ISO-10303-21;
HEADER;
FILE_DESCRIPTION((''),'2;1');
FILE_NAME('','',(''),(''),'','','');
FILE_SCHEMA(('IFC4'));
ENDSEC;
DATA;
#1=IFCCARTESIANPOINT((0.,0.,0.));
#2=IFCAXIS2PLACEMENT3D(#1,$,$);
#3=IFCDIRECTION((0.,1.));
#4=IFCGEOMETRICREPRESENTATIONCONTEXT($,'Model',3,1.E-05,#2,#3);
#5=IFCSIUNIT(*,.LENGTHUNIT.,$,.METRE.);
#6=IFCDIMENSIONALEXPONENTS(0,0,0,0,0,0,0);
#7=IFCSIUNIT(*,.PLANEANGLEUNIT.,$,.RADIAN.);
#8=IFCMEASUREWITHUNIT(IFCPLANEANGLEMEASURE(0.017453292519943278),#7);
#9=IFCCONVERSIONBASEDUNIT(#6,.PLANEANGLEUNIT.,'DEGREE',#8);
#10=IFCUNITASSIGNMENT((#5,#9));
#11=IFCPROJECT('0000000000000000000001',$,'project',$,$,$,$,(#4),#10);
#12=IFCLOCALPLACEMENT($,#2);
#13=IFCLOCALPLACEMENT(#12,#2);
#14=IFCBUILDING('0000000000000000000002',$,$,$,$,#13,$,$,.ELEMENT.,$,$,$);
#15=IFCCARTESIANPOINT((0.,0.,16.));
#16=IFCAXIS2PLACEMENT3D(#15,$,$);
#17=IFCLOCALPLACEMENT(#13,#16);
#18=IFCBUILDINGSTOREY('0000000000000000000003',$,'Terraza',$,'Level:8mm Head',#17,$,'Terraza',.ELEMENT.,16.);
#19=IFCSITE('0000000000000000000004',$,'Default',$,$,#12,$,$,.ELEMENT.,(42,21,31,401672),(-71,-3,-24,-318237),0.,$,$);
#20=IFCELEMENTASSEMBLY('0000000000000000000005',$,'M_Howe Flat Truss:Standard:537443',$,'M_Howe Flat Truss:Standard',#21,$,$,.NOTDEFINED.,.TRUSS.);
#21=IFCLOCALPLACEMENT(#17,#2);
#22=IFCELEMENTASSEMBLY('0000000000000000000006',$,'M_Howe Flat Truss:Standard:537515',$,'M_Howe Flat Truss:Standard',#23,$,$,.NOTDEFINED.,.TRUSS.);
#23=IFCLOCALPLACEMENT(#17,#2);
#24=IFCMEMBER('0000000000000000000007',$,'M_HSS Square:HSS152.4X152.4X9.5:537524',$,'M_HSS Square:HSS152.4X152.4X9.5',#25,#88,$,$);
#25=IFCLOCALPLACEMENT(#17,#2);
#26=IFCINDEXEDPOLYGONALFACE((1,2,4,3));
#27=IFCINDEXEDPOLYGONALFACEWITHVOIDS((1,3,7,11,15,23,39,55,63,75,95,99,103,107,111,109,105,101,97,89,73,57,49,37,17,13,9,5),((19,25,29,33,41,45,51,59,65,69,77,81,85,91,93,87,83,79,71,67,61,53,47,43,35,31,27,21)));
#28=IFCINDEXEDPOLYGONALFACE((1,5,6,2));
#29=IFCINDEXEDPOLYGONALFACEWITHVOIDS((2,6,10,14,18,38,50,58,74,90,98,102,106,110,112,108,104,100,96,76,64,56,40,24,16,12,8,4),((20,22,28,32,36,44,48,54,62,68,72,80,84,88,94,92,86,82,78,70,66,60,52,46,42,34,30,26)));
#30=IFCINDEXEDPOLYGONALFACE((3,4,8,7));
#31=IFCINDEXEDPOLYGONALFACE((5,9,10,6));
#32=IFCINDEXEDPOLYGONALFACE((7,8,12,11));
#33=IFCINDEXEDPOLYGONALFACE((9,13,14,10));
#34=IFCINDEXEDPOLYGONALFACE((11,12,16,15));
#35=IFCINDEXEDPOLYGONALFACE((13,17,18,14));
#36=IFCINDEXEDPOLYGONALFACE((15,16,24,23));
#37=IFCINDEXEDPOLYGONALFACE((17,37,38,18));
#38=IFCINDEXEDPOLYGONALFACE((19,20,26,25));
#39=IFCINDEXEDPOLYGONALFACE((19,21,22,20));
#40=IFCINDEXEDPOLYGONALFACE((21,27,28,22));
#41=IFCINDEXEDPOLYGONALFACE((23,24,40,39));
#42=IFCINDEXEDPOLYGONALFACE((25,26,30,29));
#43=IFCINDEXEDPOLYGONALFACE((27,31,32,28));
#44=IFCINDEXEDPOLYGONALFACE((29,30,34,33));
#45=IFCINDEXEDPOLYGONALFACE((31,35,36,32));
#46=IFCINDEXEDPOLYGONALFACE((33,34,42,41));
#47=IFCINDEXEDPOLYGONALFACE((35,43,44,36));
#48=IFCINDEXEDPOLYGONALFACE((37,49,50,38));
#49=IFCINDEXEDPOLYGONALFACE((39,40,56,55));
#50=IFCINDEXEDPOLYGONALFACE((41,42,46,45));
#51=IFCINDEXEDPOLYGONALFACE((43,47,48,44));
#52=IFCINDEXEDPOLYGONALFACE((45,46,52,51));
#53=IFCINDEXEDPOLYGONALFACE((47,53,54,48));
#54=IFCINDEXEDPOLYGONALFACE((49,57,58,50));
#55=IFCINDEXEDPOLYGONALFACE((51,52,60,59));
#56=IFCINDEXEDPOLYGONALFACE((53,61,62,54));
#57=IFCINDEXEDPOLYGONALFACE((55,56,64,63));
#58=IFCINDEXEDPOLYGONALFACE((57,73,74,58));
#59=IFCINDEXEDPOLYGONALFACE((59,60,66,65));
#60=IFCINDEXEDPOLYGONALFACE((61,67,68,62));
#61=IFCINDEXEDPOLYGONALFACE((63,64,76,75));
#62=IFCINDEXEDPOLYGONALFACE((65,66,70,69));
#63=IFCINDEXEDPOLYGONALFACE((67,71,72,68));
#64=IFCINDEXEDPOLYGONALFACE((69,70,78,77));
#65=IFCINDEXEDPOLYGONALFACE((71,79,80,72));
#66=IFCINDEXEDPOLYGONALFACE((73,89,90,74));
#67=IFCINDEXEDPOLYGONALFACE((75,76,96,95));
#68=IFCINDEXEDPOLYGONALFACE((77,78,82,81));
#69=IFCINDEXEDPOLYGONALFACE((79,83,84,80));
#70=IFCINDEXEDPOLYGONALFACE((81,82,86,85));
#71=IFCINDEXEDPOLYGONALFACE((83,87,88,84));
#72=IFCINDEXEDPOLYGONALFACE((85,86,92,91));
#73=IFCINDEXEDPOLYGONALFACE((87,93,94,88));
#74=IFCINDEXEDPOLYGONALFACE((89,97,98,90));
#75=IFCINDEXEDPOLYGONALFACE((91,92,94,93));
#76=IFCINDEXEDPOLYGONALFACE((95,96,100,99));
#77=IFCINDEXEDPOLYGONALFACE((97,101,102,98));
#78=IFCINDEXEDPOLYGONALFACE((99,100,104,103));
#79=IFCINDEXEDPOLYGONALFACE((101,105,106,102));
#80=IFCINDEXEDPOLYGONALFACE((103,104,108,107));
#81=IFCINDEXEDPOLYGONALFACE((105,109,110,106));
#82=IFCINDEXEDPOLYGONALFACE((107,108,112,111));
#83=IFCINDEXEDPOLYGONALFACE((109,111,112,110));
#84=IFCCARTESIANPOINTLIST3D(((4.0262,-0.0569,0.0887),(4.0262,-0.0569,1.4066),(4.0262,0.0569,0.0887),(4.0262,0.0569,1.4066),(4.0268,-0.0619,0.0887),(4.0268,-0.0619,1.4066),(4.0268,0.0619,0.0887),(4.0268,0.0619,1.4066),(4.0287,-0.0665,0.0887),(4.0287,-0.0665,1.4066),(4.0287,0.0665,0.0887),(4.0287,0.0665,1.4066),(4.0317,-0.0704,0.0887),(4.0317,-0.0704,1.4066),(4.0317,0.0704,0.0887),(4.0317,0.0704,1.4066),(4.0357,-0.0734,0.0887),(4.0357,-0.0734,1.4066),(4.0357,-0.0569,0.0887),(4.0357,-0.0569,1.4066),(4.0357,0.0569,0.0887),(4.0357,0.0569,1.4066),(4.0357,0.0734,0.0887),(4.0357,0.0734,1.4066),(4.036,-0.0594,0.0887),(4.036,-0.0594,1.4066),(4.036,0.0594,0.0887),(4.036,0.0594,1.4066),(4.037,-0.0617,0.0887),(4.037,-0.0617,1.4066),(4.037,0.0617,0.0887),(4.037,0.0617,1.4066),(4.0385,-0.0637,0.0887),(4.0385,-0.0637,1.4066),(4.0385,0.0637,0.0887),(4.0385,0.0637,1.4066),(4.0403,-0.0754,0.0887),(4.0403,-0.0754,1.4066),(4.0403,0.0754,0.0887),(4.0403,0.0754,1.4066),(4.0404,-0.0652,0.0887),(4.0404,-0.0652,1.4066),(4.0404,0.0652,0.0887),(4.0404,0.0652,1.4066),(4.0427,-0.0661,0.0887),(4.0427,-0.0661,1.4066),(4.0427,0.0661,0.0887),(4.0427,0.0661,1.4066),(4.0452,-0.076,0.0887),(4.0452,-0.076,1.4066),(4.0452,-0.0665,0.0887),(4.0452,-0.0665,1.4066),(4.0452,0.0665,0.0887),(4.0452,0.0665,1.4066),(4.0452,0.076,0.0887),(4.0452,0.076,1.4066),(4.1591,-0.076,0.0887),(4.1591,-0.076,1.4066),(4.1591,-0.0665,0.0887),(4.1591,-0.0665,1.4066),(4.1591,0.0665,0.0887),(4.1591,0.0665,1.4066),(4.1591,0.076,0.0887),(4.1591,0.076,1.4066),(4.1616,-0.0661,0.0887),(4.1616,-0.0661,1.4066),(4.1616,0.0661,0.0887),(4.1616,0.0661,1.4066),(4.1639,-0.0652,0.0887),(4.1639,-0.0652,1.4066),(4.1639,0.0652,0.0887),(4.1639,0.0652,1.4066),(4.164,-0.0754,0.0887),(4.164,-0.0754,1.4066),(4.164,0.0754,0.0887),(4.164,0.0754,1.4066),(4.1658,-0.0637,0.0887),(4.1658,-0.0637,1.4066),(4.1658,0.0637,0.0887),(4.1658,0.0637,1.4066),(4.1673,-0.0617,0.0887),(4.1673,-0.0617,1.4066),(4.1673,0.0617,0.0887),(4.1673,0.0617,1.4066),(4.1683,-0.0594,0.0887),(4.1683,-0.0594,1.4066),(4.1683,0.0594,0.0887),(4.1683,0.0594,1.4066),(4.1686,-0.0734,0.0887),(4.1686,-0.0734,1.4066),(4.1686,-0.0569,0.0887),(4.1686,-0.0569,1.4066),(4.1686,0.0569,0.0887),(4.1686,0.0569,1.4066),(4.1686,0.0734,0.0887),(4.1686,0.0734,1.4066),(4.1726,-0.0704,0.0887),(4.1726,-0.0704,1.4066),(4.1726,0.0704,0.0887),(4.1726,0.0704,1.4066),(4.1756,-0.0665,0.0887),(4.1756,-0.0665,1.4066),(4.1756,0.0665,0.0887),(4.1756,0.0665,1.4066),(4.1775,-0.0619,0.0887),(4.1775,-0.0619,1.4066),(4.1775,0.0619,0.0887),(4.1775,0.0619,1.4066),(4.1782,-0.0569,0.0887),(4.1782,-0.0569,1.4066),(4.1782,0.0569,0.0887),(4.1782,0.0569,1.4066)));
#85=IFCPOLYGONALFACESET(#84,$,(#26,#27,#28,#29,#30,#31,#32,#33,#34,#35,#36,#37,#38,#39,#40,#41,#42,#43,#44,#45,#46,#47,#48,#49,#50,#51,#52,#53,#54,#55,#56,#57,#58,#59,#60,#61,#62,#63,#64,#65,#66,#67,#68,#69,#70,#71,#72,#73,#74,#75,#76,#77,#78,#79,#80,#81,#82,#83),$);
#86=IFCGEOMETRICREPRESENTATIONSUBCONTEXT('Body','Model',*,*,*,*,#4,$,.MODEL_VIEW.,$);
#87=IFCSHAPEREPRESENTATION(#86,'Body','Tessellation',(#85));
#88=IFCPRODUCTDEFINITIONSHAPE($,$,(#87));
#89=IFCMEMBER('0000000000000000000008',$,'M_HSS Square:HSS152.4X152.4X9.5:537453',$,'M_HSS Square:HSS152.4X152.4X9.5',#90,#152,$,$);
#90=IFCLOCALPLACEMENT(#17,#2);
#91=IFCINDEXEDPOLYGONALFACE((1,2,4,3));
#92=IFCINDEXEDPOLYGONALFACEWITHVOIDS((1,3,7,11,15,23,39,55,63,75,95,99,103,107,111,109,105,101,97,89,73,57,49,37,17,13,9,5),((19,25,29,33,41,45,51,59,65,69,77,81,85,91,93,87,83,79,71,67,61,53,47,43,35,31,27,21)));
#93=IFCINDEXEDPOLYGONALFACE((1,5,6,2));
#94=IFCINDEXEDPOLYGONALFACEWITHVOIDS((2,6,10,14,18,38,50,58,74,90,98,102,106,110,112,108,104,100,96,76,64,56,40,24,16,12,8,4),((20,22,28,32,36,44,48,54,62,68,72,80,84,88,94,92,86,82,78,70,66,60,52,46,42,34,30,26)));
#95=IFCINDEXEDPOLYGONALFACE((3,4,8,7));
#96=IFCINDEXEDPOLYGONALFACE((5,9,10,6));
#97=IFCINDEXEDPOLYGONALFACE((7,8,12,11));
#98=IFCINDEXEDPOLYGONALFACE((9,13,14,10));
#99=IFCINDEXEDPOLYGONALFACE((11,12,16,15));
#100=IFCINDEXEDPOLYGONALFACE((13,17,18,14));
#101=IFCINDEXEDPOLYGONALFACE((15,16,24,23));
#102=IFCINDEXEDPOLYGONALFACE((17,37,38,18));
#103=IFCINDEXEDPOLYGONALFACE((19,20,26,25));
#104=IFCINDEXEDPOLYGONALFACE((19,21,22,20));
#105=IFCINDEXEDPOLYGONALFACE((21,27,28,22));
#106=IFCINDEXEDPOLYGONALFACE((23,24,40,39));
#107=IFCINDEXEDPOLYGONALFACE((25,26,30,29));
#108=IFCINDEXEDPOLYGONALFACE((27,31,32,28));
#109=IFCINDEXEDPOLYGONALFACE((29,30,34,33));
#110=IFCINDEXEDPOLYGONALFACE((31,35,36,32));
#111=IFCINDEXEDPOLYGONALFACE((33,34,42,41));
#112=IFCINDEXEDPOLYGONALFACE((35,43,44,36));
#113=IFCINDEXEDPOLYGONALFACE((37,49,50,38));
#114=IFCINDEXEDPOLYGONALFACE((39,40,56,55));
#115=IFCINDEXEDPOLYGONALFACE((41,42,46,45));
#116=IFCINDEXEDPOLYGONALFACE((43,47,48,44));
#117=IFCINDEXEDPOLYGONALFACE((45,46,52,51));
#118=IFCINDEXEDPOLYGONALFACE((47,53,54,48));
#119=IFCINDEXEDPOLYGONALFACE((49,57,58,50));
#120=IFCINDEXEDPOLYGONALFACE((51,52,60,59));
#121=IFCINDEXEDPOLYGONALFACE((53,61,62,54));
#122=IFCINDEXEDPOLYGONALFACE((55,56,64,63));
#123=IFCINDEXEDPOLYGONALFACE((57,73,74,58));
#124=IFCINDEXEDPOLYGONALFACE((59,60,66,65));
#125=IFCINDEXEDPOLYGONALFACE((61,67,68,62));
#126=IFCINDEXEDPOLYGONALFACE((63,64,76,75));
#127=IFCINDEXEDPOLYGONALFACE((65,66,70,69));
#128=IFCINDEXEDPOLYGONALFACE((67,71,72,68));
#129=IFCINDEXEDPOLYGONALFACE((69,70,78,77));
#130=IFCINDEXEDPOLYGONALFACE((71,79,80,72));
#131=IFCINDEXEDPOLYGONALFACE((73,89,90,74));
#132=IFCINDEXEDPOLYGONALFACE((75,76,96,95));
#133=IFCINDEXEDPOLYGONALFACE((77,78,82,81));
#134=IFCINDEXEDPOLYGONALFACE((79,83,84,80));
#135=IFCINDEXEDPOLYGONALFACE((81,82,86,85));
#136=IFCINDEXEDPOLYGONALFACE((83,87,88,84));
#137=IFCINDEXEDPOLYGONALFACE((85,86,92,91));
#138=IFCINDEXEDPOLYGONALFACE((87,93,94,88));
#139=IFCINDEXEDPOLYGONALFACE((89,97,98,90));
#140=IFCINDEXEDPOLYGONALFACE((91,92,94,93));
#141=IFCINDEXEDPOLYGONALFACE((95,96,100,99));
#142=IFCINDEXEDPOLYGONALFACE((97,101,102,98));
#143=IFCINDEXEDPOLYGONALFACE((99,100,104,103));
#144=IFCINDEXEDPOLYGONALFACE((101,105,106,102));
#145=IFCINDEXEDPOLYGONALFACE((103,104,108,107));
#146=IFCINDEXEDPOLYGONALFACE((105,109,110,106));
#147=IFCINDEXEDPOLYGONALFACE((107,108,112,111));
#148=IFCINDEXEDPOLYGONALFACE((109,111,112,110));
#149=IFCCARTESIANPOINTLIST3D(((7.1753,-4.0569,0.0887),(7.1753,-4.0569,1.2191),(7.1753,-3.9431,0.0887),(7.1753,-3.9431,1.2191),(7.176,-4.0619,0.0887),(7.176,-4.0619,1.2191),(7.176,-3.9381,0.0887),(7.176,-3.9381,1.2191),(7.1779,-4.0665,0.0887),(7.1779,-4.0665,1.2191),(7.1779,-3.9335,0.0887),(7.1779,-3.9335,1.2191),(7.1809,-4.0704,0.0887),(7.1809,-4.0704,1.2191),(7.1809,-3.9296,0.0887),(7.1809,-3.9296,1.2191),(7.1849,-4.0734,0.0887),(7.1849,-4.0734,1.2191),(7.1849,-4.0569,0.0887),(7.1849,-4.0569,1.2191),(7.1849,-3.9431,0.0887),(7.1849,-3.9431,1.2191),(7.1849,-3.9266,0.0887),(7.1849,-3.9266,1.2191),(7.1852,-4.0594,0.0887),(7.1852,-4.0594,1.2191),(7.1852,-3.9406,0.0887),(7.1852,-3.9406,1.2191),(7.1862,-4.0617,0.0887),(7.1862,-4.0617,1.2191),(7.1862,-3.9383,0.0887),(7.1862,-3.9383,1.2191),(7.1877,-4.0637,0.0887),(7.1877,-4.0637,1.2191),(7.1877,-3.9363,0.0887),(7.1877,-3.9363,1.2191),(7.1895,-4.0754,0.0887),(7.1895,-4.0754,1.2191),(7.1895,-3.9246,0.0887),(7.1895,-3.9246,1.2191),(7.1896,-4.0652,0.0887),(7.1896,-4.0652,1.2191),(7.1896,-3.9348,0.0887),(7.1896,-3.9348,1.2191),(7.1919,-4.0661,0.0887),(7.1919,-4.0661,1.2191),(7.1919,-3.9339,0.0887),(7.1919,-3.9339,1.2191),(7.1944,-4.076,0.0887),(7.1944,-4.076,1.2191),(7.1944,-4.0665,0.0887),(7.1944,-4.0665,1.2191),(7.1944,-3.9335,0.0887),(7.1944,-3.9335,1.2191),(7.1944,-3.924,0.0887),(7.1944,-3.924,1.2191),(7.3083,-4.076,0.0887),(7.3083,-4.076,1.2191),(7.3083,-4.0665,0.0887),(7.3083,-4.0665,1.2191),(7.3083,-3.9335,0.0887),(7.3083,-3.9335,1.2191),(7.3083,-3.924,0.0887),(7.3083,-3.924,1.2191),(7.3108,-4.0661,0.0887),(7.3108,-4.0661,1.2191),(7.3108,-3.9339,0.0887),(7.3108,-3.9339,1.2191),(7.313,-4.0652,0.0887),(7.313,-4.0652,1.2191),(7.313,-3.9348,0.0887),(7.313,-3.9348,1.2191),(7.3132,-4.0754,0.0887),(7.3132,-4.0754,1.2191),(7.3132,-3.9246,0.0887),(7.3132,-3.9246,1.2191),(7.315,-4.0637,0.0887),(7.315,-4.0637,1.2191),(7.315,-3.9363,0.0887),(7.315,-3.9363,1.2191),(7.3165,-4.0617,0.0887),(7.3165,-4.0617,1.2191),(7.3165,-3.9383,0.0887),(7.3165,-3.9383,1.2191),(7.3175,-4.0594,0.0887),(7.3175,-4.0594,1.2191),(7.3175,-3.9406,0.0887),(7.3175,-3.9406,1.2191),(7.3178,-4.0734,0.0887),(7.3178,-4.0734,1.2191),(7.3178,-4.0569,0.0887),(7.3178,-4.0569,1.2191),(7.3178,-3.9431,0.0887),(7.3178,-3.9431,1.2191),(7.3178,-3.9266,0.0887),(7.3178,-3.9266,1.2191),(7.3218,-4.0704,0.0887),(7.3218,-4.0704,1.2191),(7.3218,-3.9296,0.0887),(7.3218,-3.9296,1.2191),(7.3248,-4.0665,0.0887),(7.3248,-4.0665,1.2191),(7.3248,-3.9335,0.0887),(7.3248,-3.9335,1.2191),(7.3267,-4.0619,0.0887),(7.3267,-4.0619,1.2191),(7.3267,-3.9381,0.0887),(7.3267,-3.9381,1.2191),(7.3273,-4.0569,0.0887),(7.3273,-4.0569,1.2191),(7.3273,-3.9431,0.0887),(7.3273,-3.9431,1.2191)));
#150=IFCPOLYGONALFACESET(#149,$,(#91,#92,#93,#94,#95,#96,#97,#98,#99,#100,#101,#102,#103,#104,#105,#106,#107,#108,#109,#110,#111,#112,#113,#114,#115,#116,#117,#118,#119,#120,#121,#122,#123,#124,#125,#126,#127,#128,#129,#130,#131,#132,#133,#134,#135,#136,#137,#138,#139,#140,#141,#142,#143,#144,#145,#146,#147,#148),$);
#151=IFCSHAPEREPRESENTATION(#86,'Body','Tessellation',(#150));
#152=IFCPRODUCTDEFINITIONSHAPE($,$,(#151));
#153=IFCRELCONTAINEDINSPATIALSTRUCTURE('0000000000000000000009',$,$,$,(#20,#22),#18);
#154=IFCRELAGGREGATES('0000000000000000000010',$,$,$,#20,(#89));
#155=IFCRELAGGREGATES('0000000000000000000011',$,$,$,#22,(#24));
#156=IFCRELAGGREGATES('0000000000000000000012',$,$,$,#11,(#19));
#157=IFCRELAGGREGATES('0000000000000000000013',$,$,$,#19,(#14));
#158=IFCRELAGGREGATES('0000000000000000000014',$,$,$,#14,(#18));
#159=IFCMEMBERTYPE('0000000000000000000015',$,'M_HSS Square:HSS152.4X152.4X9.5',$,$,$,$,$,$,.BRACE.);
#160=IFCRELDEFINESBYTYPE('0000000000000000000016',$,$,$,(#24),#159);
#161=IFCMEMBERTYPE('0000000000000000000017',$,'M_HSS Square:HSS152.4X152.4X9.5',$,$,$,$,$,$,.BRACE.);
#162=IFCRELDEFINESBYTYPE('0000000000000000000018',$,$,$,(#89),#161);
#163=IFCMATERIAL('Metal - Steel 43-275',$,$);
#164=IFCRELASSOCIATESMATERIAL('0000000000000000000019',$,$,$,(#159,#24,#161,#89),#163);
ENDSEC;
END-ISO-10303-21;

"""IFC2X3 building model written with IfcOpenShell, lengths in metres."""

from ifc_helpers import new_model, entity, si_unit, converted_unit, direction, frame, frame_2d, origin, place, context, subcontext, project, spatial, polyline, circle_curve, parameter, trimmed, segment, composite_curve, outline, extrude, source, transform, mapped, material, type_object, type_shapes, element, aggregate, save


model = new_model("IFC2X3")

# Units and contexts
model_context = context("Model", 3, precision=1e-05, world=origin(), true_north=direction((0.0, 1.0)))
body_context = subcontext(model_context, "Body", "Model", "MODEL_VIEW")
ifc_project = project(units=[si_unit("LENGTHUNIT", "METRE"), converted_unit("PLANEANGLEUNIT", "DEGREE", entity("IfcPlaneAngleMeasure", 0.017453292519943278), si_unit("PLANEANGLEUNIT", "RADIAN"), dimensions=[0, 0, 0, 0, 0, 0, 0])], contexts=[model_context])

# Site, building, storey
site_placement = place(None, origin())
site = spatial("IfcSite", under=ifc_project, at=site_placement, Name="Default", CompositionType="ELEMENT", RefLatitude=(42, 21, 31, 401672), RefLongitude=(-71, -3, -24, -318237), RefElevation=0.0)
building_placement = place(site_placement, origin())
building = spatial("IfcBuilding", under=site, at=building_placement, CompositionType="ELEMENT")
storey_placement = place(building_placement, frame((0.0, 0.0, 16.0)))
storey = spatial("IfcBuildingStorey", under=building, at=storey_placement, Name="Terraza", ObjectType="Level:8mm Head", LongName="Terraza", CompositionType="ELEMENT", Elevation=16.0)

# Element assemblies
ifc_material_1 = material(Name="Metal - Steel 43-275")
assembly_1_placement = place(storey_placement, origin())
assembly_1 = element("IfcElementAssembly", 1, at=assembly_1_placement, inside=storey, Name="M_Howe Flat Truss:Standard:537443", ObjectType="M_Howe Flat Truss:Standard", AssemblyPlace="NOTDEFINED", PredefinedType="TRUSS")
assembly_2_placement = place(storey_placement, origin())
assembly_2 = element("IfcElementAssembly", 2, at=assembly_2_placement, inside=storey, Name="M_Howe Flat Truss:Standard:537515", ObjectType="M_Howe Flat Truss:Standard", AssemblyPlace="NOTDEFINED", PredefinedType="TRUSS")

# Members
member_type_1 = type_object("IfcMemberType", Name="M_HSS Square:HSS152.4X152.4X9.5", PredefinedType="BRACE", material=ifc_material_1)
shared_shape_1 = source(origin(), body_context, "Body", "SweptSolid", [
    extrude(outline(composite_curve([segment(polyline([(-0.0569, -0.076), (0.0569, -0.076)]), True, "CONTINUOUS"), segment(trimmed(circle_curve(frame_2d((0.0569, -0.0569), x_axis=(0.0, 1.0)), 0.0191), [parameter(180.0)], [parameter(270.0)], True, "PARAMETER"), True, "CONTINUOUS"), segment(polyline([(0.076, -0.0569), (0.076, 0.0569)]), True, "CONTINUOUS"), segment(trimmed(circle_curve(frame_2d((0.0569, 0.0569), x_axis=(0.0, 1.0)), 0.0191), [parameter(270.0)], [parameter(0.0)], True, "PARAMETER"), True, "CONTINUOUS"), segment(polyline([(0.0569, 0.076), (-0.0569, 0.076)]), True, "CONTINUOUS"), segment(trimmed(circle_curve(frame_2d((-0.0569, 0.0569), x_axis=(0.0, 1.0)), 0.0191), [parameter(0.0)], [parameter(90.0)], True, "PARAMETER"), True, "CONTINUOUS"), segment(polyline([(-0.076, 0.0569), (-0.076, -0.0569)]), True, "CONTINUOUS"), segment(trimmed(circle_curve(frame_2d((-0.0569, -0.0569), x_axis=(0.0, 1.0)), 0.0191), [parameter(90.0)], [parameter(180.0)], True, "PARAMETER"), True, "CONTINUOUS")], self_intersect=False), holes=[composite_curve([segment(trimmed(circle_curve(frame_2d((-0.0569, 0.0569), x_axis=(0.0, 1.0)), 0.0095), [parameter(360.0)], [parameter(90.0)], True, "PARAMETER"), False, "CONTINUOUS"), segment(polyline([(-0.0569, 0.0665), (0.0569, 0.0665)]), True, "CONTINUOUS"), segment(trimmed(circle_curve(frame_2d((0.0569, 0.0569), x_axis=(0.0, 1.0)), 0.0095), [parameter(270.0)], [parameter(360.0)], True, "PARAMETER"), False, "CONTINUOUS"), segment(polyline([(0.0665, 0.0569), (0.0665, -0.0569)]), True, "CONTINUOUS"), segment(trimmed(circle_curve(frame_2d((0.0569, -0.0569), x_axis=(0.0, 1.0)), 0.0095), [parameter(180.0)], [parameter(270.0)], True, "PARAMETER"), False, "CONTINUOUS"), segment(polyline([(0.0569, -0.0665), (-0.0569, -0.0665)]), True, "CONTINUOUS"), segment(trimmed(circle_curve(frame_2d((-0.0569, -0.0569), x_axis=(0.0, 1.0)), 0.0095), [parameter(90.0)], [parameter(180.0)], True, "PARAMETER"), False, "CONTINUOUS"), segment(polyline([(-0.0665, -0.0569), (-0.0665, 0.0569)]), True, "CONTINUOUS")], self_intersect=False)]), frame((-0.6613, 0.0, 0.0), z_axis=(1.0, 0.0, 0.0), x_axis=(0.0, 0.0, -1.0)), (0.0, 0.0, 1.0), 1.3179),
])
type_shapes(member_type_1, [shared_shape_1])
member_1_placement = place(assembly_2_placement, frame((4.1022, 0.0, 0.75), z_axis=(1.0, 0.0, 0.0), x_axis=(0.0, 0.0, 1.0)))
member_1 = element("IfcMember", 3, at=member_1_placement, type_object=member_type_1, material=ifc_material_1, Name="M_HSS Square:HSS152.4X152.4X9.5:537524", ObjectType="M_HSS Square:HSS152.4X152.4X9.5", context=body_context, shape_type="MappedRepresentation", body=[
    mapped(shared_shape_1, transform((0.0, 0.0, 0.0), scale=1.0)),
])
member_type_2 = type_object("IfcMemberType", Name="M_HSS Square:HSS152.4X152.4X9.5", PredefinedType="BRACE", material=ifc_material_1)
shared_shape_2 = source(origin(), body_context, "Body", "SweptSolid", [
    extrude(outline(composite_curve([segment(polyline([(-0.0569, -0.076), (0.0569, -0.076)]), True, "CONTINUOUS"), segment(trimmed(circle_curve(frame_2d((0.0569, -0.0569), x_axis=(0.0, 1.0)), 0.0191), [parameter(180.0)], [parameter(270.0)], True, "PARAMETER"), True, "CONTINUOUS"), segment(polyline([(0.076, -0.0569), (0.076, 0.0569)]), True, "CONTINUOUS"), segment(trimmed(circle_curve(frame_2d((0.0569, 0.0569), x_axis=(0.0, 1.0)), 0.0191), [parameter(270.0)], [parameter(0.0)], True, "PARAMETER"), True, "CONTINUOUS"), segment(polyline([(0.0569, 0.076), (-0.0569, 0.076)]), True, "CONTINUOUS"), segment(trimmed(circle_curve(frame_2d((-0.0569, 0.0569), x_axis=(0.0, 1.0)), 0.0191), [parameter(0.0)], [parameter(90.0)], True, "PARAMETER"), True, "CONTINUOUS"), segment(polyline([(-0.076, 0.0569), (-0.076, -0.0569)]), True, "CONTINUOUS"), segment(trimmed(circle_curve(frame_2d((-0.0569, -0.0569), x_axis=(0.0, 1.0)), 0.0191), [parameter(90.0)], [parameter(180.0)], True, "PARAMETER"), True, "CONTINUOUS")], self_intersect=False), holes=[composite_curve([segment(trimmed(circle_curve(frame_2d((-0.0569, 0.0569), x_axis=(0.0, 1.0)), 0.0095), [parameter(360.0)], [parameter(90.0)], True, "PARAMETER"), False, "CONTINUOUS"), segment(polyline([(-0.0569, 0.0665), (0.0569, 0.0665)]), True, "CONTINUOUS"), segment(trimmed(circle_curve(frame_2d((0.0569, 0.0569), x_axis=(0.0, 1.0)), 0.0095), [parameter(270.0)], [parameter(360.0)], True, "PARAMETER"), False, "CONTINUOUS"), segment(polyline([(0.0665, 0.0569), (0.0665, -0.0569)]), True, "CONTINUOUS"), segment(trimmed(circle_curve(frame_2d((0.0569, -0.0569), x_axis=(0.0, 1.0)), 0.0095), [parameter(180.0)], [parameter(270.0)], True, "PARAMETER"), False, "CONTINUOUS"), segment(polyline([(0.0569, -0.0665), (-0.0569, -0.0665)]), True, "CONTINUOUS"), segment(trimmed(circle_curve(frame_2d((-0.0569, -0.0569), x_axis=(0.0, 1.0)), 0.0095), [parameter(90.0)], [parameter(180.0)], True, "PARAMETER"), False, "CONTINUOUS"), segment(polyline([(-0.0665, -0.0569), (-0.0665, 0.0569)]), True, "CONTINUOUS")], self_intersect=False)]), frame((-0.5675, 0.0, 0.0), z_axis=(1.0, 0.0, 0.0), x_axis=(0.0, 0.0, -1.0)), (0.0, 0.0, 1.0), 1.1304),
])
type_shapes(member_type_2, [shared_shape_2])
member_2_placement = place(assembly_1_placement, frame((7.2513, -4.0, 0.6562), z_axis=(1.0, 0.0, 0.0), x_axis=(0.0, 0.0, 1.0)))
member_2 = element("IfcMember", 4, at=member_2_placement, type_object=member_type_2, material=ifc_material_1, Name="M_HSS Square:HSS152.4X152.4X9.5:537453", ObjectType="M_HSS Square:HSS152.4X152.4X9.5", context=body_context, shape_type="MappedRepresentation", body=[
    mapped(shared_shape_2, transform((0.0, 0.0, 0.0), scale=1.0)),
])
aggregate(assembly_1, [member_2])
aggregate(assembly_2, [member_1])

save(model, "model.ifc")
